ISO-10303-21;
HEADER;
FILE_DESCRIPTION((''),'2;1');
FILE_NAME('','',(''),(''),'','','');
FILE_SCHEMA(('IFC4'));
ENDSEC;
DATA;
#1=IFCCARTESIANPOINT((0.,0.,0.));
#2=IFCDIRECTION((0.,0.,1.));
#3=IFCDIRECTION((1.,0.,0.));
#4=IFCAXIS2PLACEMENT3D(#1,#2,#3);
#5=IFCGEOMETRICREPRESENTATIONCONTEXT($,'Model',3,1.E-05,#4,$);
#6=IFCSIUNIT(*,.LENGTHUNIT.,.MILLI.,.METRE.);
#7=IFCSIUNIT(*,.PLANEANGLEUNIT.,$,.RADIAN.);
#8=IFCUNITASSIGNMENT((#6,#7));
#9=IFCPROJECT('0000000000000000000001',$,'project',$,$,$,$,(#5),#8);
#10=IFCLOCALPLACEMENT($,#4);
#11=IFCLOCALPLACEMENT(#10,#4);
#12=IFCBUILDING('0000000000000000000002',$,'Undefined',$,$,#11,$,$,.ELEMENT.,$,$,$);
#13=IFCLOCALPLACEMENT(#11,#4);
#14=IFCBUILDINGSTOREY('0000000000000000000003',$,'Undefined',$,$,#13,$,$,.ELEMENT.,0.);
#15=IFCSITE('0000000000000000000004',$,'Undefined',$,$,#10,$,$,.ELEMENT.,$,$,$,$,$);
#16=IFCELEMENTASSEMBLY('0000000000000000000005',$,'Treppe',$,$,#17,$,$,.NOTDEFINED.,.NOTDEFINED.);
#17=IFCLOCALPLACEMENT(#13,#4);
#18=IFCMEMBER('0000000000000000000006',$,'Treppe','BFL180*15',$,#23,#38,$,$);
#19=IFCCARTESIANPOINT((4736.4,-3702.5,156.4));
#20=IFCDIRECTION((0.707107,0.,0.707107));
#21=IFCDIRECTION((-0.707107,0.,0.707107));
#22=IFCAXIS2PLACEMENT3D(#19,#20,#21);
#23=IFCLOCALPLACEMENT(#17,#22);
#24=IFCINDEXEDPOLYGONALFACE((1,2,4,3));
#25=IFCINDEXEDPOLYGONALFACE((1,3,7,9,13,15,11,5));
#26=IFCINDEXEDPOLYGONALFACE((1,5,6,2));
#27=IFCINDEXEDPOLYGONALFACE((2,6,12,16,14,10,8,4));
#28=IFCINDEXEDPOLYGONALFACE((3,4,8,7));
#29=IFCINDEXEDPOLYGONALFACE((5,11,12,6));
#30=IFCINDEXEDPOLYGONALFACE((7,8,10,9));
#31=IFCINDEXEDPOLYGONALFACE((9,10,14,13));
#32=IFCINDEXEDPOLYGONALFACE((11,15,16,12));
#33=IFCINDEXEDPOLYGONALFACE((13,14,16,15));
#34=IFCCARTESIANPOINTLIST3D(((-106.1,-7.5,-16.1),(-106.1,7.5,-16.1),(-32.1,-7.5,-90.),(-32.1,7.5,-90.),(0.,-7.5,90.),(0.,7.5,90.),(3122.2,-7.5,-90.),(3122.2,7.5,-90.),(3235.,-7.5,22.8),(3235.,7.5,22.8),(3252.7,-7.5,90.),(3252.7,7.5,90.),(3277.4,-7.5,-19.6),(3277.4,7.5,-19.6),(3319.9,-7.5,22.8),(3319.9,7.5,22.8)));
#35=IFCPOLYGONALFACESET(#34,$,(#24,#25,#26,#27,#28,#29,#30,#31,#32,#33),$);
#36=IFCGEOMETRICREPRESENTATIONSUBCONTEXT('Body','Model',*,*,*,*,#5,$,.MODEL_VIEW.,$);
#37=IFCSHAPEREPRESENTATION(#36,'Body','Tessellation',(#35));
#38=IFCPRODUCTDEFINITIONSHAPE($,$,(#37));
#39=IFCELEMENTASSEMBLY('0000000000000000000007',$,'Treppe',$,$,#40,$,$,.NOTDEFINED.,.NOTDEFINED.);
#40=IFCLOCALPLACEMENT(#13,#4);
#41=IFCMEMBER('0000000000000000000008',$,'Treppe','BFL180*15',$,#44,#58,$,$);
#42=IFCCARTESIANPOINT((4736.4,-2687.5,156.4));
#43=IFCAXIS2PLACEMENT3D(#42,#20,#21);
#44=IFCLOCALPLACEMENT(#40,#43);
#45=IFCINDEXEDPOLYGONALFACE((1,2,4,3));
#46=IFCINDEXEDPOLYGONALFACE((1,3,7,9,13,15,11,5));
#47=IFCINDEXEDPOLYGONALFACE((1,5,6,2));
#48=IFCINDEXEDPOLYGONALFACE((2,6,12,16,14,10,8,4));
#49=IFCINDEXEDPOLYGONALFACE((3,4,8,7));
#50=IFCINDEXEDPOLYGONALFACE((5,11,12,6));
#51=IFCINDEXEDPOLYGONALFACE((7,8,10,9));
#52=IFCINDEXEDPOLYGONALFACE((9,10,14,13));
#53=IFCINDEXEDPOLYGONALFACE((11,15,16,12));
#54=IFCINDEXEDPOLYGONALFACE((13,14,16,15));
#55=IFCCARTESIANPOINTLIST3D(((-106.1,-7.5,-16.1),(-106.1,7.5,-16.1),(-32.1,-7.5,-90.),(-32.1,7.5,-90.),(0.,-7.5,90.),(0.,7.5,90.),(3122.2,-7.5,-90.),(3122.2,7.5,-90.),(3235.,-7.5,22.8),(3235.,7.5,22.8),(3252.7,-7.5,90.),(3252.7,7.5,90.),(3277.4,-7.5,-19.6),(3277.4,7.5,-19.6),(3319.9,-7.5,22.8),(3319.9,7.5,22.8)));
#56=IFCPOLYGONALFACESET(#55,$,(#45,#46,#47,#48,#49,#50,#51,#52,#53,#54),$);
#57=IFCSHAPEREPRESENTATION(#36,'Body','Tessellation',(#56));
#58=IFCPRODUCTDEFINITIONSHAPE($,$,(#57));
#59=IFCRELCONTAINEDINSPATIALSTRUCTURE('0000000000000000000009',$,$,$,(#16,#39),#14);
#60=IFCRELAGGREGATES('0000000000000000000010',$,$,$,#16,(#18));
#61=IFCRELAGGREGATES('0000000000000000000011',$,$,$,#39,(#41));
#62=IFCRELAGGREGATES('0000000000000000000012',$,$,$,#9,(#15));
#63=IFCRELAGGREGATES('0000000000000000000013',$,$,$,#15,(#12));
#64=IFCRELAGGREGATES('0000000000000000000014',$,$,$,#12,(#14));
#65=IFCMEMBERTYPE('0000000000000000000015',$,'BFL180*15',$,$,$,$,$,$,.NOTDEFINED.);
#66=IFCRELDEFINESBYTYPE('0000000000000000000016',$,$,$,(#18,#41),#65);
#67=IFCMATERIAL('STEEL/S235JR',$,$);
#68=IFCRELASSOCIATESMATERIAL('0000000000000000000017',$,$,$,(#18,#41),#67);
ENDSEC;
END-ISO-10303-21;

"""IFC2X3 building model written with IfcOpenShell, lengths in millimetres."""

from ifc_helpers import new_model, si_unit, frame, origin_with_axes, origin_2d_with_axis, place, context, subcontext, project, spatial, polyline, rectangle, outline, extrude, boolean, halfspace, material, type_object, element, aggregate, save


model = new_model("IFC2X3")

# Units and contexts
model_context = context("Model", 3, precision=1e-05, world=origin_with_axes())
body_context = subcontext(model_context, "Body", "Model", "MODEL_VIEW")
ifc_project = project(units=[si_unit("LENGTHUNIT", "METRE", prefix="MILLI"), si_unit("PLANEANGLEUNIT", "RADIAN")], contexts=[model_context])

# Site, building, storey
site_placement = place(None, origin_with_axes())
site = spatial("IfcSite", under=ifc_project, at=site_placement, Name="Undefined", CompositionType="ELEMENT")
building_placement = place(site_placement, origin_with_axes())
building = spatial("IfcBuilding", under=site, at=building_placement, Name="Undefined", CompositionType="ELEMENT")
storey_placement = place(building_placement, origin_with_axes())
storey = spatial("IfcBuildingStorey", under=building, at=storey_placement, Name="Undefined", CompositionType="ELEMENT", Elevation=0.0)

# Element assemblies, members
assembly_1_placement = place(storey_placement, origin_with_axes())
assembly_1 = element("IfcElementAssembly", 1, at=assembly_1_placement, inside=storey, Name="Treppe", AssemblyPlace="NOTDEFINED", PredefinedType="NOTDEFINED")
ifc_material_1 = material(Name="STEEL/S235JR")
member_type = type_object("IfcMemberType", Name="BFL180*15", PredefinedType="NOTDEFINED")
member_1_placement = place(assembly_1_placement, frame((4736.4, -3702.5, 156.4), z_axis=(0.707107, 0.0, 0.707107), x_axis=(-0.707107, 0.0, 0.707107)))
member_1 = element("IfcMember", 2, at=member_1_placement, type_object=member_type, material=ifc_material_1, Name="Treppe", Description="BFL180*15", context=body_context, shape_type="CSG", body=[
    boolean("DIFFERENCE", boolean("DIFFERENCE", boolean("DIFFERENCE", boolean("DIFFERENCE", boolean("DIFFERENCE", extrude(rectangle(XDim=15.0, YDim=180.0, at=origin_2d_with_axis()), frame((3382.0, 0.0, 0.0), z_axis=(-1.0, 0.0, 0.0), x_axis=(0.0, -1.0, 0.0)), (0.0, 0.0, 1.0), 3511.2), extrude(outline(polyline([(0.0, 0.0), (65.0, 0.0), (65.0, 180.0), (0.0, 180.0), (0.0, 0.0)])), frame((3235.0, -77.5, 22.8), z_axis=(0.0, 1.0, 0.0), x_axis=(0.707107, 0.0, -0.707107)), (0.0, 0.0, 1.0), 140.0)), halfspace(frame((3390.6, 7.5, 93.5), z_axis=(0.707107, 0.0, -0.707107), x_axis=(-0.707107, 0.0, -0.707107)), False)), halfspace(frame((-39.2, 7.5, -82.9), z_axis=(-0.707107, 0.0, -0.707107), x_axis=(-0.707107, 0.0, 0.707107)), False)), halfspace(frame((3252.7, -7.5, 90.0), z_axis=(0.707107, 0.0, 0.707107), x_axis=(0.0, 1.0, 0.0)), False)), halfspace(frame((0.0, -7.5, 90.0), z_axis=(0.707107, 0.0, -0.707107), x_axis=(0.0, 1.0, 0.0)), True)),
])
assembly_2_placement = place(storey_placement, origin_with_axes())
assembly_2 = element("IfcElementAssembly", 3, at=assembly_2_placement, inside=storey, Name="Treppe", AssemblyPlace="NOTDEFINED", PredefinedType="NOTDEFINED")
member_2_placement = place(assembly_2_placement, frame((4736.4, -2687.5, 156.4), z_axis=(0.707107, 0.0, 0.707107), x_axis=(-0.707107, 0.0, 0.707107)))
member_2 = element("IfcMember", 4, at=member_2_placement, type_object=member_type, material=ifc_material_1, Name="Treppe", Description="BFL180*15", context=body_context, shape_type="CSG", body=[
    boolean("DIFFERENCE", boolean("DIFFERENCE", boolean("DIFFERENCE", boolean("DIFFERENCE", boolean("DIFFERENCE", extrude(rectangle(XDim=15.0, YDim=180.0, at=origin_2d_with_axis()), frame((3382.0, 0.0, 0.0), z_axis=(-1.0, 0.0, 0.0), x_axis=(0.0, -1.0, 0.0)), (0.0, 0.0, 1.0), 3511.2), extrude(outline(polyline([(0.0, 0.0), (65.0, 0.0), (65.0, 180.0), (0.0, 180.0), (0.0, 0.0)])), frame((3235.0, -77.5, 22.8), z_axis=(0.0, 1.0, 0.0), x_axis=(0.707107, 0.0, -0.707107)), (0.0, 0.0, 1.0), 140.0)), halfspace(frame((3390.6, 7.5, 93.5), z_axis=(0.707107, 0.0, -0.707107), x_axis=(-0.707107, 0.0, -0.707107)), False)), halfspace(frame((-39.2, 7.5, -82.9), z_axis=(-0.707107, 0.0, -0.707107), x_axis=(-0.707107, 0.0, 0.707107)), False)), halfspace(frame((3252.7, -7.5, 90.0), z_axis=(0.707107, 0.0, 0.707107), x_axis=(0.0, 1.0, 0.0)), False)), halfspace(frame((0.0, -7.5, 90.0), z_axis=(0.707107, 0.0, -0.707107), x_axis=(0.0, 1.0, 0.0)), True)),
])

aggregate(assembly_1, [member_1])
aggregate(assembly_2, [member_2])

save(model, "model.ifc")
